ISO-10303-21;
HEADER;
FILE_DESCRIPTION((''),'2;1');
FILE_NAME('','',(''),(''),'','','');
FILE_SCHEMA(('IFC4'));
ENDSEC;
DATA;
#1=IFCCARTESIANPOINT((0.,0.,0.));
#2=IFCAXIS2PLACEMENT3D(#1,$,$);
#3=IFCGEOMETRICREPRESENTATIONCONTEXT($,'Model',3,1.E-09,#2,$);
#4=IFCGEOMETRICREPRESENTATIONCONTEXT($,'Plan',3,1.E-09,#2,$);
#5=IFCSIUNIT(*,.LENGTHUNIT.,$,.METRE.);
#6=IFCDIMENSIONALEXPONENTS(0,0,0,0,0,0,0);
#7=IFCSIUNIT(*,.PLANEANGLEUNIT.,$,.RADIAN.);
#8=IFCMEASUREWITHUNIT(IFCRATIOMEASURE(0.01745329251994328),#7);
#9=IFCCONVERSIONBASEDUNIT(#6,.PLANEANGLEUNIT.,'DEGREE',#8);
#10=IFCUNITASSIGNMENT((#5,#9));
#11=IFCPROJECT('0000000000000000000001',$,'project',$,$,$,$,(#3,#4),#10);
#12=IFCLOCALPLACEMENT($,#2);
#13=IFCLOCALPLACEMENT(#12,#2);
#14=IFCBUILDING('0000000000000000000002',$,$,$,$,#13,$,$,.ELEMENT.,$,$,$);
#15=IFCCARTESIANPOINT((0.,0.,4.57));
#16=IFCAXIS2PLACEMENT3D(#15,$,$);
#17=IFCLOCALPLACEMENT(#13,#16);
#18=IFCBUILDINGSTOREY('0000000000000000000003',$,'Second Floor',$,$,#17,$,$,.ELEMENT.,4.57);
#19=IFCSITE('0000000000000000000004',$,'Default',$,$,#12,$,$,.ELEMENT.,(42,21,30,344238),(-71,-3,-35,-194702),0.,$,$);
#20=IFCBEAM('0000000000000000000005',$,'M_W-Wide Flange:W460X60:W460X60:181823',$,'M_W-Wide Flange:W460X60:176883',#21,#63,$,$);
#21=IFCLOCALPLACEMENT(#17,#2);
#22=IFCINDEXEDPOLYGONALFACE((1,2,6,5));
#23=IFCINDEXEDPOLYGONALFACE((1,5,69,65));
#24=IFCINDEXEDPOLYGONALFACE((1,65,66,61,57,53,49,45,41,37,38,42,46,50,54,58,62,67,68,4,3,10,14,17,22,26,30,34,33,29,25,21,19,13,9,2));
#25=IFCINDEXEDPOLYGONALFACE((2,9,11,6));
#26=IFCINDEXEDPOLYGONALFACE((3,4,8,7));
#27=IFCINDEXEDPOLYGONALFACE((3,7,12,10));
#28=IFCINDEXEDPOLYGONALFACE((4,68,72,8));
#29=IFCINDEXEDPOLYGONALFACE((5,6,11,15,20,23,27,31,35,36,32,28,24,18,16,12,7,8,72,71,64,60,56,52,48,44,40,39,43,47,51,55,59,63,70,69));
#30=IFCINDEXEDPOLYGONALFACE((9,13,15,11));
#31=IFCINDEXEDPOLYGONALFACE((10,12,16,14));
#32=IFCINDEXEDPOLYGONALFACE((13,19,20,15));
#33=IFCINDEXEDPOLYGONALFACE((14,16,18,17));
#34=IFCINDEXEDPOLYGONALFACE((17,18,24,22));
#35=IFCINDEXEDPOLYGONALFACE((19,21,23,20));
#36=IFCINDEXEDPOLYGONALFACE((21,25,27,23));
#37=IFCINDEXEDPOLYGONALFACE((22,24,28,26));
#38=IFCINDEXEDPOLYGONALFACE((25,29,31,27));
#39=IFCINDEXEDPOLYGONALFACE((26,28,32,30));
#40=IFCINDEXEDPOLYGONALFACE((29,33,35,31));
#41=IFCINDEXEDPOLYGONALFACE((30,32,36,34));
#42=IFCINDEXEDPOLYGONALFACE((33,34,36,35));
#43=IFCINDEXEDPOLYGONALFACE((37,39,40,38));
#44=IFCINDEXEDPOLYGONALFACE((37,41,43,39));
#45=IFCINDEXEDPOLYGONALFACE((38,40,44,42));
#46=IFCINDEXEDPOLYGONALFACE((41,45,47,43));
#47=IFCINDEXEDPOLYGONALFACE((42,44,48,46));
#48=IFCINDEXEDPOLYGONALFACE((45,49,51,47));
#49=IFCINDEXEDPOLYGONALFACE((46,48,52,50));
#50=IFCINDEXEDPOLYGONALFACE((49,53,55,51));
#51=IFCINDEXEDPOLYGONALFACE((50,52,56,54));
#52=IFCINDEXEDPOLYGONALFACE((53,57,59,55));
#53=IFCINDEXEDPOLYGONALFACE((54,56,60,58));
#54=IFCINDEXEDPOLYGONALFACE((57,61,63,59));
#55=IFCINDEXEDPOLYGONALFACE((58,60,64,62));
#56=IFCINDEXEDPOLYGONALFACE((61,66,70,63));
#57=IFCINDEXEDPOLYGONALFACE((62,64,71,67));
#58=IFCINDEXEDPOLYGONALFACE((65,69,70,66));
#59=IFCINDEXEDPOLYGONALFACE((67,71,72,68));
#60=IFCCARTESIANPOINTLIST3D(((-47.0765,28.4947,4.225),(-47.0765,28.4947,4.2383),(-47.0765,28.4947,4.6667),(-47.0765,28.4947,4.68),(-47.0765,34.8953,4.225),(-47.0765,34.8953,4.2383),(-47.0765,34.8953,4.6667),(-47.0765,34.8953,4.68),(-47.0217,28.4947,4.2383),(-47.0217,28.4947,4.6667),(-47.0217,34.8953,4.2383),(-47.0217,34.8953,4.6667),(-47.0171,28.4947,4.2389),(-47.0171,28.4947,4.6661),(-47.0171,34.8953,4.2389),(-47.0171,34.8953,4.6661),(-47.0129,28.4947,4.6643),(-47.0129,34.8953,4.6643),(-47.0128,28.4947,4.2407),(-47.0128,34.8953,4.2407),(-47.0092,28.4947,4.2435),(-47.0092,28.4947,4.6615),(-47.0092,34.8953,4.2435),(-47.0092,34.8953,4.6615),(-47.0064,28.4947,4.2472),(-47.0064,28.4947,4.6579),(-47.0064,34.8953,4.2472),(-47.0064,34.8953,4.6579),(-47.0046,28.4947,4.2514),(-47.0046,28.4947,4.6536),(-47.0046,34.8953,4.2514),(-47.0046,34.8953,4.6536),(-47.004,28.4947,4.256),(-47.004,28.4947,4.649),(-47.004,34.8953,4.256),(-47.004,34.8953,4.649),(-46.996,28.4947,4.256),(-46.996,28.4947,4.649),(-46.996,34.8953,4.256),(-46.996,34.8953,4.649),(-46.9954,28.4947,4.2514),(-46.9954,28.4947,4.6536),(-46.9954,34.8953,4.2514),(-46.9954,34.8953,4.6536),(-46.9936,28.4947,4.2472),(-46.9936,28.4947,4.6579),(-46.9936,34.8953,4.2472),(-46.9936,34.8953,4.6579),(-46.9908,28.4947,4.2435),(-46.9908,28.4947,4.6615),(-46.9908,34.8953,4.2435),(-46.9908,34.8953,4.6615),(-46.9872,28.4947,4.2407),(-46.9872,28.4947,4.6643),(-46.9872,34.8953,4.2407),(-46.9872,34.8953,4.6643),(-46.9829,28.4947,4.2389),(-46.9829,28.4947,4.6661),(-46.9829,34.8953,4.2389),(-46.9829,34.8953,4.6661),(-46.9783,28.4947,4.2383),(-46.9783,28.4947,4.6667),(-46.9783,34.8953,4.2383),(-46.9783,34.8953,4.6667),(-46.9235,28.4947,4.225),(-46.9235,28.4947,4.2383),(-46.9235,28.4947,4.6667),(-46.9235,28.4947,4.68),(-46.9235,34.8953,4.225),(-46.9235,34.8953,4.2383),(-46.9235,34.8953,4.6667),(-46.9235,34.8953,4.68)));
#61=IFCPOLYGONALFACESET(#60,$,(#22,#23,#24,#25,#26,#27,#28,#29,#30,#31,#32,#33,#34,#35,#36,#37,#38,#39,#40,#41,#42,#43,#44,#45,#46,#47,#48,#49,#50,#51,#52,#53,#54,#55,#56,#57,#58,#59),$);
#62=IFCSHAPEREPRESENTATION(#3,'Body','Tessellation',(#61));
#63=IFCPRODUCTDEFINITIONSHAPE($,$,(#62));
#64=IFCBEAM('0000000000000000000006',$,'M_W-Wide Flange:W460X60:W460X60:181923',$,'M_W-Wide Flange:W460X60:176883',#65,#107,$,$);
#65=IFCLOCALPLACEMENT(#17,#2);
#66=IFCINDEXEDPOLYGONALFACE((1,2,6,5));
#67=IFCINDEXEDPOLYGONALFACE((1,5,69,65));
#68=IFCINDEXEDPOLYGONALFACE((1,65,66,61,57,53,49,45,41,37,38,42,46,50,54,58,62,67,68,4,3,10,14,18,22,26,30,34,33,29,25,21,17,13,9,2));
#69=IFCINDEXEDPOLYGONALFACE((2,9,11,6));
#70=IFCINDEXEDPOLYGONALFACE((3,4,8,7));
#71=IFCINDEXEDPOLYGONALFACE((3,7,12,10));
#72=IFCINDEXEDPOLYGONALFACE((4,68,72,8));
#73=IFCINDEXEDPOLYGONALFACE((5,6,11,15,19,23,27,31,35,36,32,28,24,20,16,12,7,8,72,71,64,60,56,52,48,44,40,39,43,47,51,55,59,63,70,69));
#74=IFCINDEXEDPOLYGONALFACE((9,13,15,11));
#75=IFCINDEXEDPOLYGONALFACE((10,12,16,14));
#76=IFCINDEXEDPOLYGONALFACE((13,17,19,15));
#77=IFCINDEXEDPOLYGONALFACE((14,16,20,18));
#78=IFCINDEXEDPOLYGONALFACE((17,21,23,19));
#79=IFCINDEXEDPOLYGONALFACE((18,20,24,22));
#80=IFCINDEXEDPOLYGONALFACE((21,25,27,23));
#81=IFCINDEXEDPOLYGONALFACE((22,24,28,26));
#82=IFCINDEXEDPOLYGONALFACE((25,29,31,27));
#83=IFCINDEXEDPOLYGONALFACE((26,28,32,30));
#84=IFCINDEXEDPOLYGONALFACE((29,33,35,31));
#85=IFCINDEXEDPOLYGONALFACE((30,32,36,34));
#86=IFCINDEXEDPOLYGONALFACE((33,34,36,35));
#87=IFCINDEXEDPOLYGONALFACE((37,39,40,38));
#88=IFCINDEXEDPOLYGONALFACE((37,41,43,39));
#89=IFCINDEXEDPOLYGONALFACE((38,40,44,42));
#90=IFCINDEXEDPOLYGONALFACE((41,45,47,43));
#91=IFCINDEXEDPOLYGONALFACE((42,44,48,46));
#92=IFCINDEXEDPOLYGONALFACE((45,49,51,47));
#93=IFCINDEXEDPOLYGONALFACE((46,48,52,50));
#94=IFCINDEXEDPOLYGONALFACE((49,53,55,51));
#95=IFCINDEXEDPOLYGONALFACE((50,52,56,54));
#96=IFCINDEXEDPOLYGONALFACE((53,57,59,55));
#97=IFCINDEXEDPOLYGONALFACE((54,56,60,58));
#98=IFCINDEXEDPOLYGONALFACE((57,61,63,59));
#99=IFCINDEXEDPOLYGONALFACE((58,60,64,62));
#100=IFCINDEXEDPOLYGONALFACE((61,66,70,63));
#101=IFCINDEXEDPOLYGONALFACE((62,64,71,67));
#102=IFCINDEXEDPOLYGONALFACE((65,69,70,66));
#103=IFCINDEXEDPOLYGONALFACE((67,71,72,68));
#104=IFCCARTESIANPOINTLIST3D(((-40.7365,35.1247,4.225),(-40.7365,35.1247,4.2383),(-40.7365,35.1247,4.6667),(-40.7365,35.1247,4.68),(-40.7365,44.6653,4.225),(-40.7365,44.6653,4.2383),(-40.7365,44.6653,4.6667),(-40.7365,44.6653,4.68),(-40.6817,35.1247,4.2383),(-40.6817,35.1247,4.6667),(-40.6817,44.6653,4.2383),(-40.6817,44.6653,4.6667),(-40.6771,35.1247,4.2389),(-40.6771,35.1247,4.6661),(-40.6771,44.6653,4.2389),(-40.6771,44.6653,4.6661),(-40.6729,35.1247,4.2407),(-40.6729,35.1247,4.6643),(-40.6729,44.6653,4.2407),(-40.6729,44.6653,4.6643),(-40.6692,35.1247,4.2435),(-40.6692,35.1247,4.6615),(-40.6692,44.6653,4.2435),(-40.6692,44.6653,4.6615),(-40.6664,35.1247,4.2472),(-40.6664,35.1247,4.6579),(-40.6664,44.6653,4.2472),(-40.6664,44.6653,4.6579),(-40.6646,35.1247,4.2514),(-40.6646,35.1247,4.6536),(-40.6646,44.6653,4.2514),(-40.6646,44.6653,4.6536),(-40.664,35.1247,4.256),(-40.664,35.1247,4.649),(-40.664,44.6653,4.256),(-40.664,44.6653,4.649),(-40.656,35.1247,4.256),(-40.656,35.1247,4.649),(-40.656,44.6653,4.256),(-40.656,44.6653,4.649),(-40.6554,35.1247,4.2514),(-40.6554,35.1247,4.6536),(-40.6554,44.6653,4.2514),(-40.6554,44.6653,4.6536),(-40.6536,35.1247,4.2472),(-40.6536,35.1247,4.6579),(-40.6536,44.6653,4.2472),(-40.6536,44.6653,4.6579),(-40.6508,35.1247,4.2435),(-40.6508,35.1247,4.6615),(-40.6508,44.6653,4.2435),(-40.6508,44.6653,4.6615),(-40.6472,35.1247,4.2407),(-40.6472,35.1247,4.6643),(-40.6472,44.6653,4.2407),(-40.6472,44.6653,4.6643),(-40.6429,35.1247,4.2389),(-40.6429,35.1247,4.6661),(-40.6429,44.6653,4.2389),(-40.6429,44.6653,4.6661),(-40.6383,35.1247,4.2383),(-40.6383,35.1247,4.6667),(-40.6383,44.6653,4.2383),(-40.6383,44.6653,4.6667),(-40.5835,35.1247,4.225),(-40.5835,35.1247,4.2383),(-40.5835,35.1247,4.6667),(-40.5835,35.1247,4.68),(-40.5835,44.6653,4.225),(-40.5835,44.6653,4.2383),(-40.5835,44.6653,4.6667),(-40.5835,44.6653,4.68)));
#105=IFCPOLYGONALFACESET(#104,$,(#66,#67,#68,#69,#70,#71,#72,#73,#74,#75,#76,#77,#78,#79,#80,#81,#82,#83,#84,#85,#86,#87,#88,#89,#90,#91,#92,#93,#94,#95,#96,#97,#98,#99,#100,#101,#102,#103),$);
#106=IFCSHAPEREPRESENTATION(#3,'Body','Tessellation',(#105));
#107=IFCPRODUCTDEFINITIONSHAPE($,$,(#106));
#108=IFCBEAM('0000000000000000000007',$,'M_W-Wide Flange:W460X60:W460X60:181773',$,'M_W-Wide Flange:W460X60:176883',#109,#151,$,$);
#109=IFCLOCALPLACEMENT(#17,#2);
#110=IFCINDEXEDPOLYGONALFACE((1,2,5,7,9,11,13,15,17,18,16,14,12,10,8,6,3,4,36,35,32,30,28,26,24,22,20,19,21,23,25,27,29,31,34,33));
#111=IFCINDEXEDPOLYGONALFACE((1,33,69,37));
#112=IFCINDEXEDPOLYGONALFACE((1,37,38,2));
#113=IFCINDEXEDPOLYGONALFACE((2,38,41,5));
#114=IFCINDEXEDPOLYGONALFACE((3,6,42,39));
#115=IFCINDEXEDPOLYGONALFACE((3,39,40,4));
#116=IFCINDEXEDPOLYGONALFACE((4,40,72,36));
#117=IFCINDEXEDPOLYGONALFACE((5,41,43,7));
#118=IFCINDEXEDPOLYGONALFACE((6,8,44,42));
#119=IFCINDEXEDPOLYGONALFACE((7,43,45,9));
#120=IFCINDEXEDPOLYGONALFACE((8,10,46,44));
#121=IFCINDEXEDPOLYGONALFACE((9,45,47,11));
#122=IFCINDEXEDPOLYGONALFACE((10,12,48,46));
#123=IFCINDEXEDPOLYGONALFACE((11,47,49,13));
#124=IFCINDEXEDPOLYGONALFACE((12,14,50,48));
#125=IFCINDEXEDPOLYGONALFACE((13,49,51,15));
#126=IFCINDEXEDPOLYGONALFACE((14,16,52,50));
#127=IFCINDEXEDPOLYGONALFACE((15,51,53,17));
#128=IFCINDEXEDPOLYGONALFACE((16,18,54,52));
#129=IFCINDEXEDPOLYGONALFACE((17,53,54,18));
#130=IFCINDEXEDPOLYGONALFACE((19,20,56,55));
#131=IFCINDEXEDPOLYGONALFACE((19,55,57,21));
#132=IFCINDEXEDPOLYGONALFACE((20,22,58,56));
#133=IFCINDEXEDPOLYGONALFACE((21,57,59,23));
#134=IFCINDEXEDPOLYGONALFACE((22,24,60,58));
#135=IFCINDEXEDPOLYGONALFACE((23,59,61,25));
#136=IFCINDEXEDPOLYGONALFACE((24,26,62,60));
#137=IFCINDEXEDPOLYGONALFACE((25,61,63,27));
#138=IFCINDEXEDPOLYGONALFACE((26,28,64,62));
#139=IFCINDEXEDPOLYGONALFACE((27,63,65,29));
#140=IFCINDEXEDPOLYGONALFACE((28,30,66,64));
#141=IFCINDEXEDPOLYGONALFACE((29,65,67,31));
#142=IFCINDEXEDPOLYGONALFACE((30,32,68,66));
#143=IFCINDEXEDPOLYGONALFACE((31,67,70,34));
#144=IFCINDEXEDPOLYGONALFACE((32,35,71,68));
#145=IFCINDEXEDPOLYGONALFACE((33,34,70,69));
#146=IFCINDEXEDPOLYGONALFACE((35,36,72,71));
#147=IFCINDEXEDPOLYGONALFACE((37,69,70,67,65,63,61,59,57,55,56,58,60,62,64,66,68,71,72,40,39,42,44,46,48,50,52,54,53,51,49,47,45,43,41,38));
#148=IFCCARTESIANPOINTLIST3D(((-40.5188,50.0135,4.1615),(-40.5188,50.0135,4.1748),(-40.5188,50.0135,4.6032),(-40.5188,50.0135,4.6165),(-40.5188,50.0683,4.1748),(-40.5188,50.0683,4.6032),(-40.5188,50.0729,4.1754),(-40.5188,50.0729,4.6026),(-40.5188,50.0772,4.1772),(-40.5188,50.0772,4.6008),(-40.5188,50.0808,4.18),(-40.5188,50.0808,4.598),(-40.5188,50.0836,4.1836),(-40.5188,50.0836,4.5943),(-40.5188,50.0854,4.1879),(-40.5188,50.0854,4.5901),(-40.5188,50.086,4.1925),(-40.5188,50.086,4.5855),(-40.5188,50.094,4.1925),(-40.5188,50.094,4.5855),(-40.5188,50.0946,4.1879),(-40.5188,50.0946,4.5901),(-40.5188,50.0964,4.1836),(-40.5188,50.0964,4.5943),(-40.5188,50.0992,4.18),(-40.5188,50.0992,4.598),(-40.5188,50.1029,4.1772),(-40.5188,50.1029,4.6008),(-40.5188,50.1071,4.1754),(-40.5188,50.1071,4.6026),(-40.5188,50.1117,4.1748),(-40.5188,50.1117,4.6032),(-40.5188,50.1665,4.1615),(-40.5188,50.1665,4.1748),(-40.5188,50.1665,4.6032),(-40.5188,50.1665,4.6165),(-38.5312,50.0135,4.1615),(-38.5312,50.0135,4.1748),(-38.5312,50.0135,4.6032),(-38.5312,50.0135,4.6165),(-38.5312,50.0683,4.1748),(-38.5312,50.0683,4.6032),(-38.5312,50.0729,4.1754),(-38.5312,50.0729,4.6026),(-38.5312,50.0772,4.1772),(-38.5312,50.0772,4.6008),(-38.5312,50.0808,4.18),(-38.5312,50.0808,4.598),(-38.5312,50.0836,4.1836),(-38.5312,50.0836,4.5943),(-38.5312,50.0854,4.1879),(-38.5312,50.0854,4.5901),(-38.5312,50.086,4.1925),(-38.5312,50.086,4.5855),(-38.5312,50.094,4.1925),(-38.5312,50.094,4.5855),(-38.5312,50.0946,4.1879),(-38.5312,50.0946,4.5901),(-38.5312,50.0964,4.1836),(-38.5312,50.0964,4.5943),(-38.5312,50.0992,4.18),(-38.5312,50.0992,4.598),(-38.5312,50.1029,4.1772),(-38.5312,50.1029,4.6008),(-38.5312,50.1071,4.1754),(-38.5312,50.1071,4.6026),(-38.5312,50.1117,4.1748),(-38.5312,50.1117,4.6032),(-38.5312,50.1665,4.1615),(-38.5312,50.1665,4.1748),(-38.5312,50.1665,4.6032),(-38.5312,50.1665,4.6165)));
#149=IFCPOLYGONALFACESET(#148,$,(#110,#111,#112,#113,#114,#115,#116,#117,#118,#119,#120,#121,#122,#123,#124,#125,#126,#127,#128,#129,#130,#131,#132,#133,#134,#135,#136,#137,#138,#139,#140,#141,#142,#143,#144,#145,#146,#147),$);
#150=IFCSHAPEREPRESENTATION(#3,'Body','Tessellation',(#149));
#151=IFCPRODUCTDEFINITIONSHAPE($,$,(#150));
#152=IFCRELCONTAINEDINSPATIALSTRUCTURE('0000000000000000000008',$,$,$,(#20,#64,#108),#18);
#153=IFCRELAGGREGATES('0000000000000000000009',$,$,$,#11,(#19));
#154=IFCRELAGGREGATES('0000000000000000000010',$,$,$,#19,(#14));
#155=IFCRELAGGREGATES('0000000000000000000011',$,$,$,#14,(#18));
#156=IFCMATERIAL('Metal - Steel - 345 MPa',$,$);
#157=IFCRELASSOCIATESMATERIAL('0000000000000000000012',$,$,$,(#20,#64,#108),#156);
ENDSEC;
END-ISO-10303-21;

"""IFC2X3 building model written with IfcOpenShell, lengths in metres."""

from ifc_helpers import new_model, entity, si_unit, converted_unit, frame, frame_2d, origin, place, context, project, spatial, polyline, circle_curve, parameter, trimmed, segment, composite_curve, outline, extrude, material, element, save


model = new_model("IFC2X3")

# Units and contexts
model_context = context("Model", 3, precision=1e-09, world=origin())
plan_context = context("Plan", 3, precision=1e-09, world=origin())
ifc_project = project(units=[si_unit("LENGTHUNIT", "METRE"), converted_unit("PLANEANGLEUNIT", "DEGREE", entity("IfcRatioMeasure", 0.01745329251994328), si_unit("PLANEANGLEUNIT", "RADIAN"), dimensions=[0, 0, 0, 0, 0, 0, 0])], contexts=[model_context, plan_context])

# Site, building, storey
site_placement = place(None, origin())
site = spatial("IfcSite", under=ifc_project, at=site_placement, Name="Default", CompositionType="ELEMENT", RefLatitude=(42, 21, 30, 344238), RefLongitude=(-71, -3, -35, -194702), RefElevation=0.0)
building_placement = place(site_placement, origin())
building = spatial("IfcBuilding", under=site, at=building_placement, CompositionType="ELEMENT")
storey_placement = place(building_placement, frame((0.0, 0.0, 4.57)))
storey = spatial("IfcBuildingStorey", under=building, at=storey_placement, Name="Second Floor", CompositionType="ELEMENT", Elevation=4.57)

# Shared definitions
ifc_material_1 = material(Name="Metal - Steel - 345 MPa")

# Beams
beam_1_placement = place(storey_placement, frame((-47.0, 35.0072, 4.68), z_axis=(0.0, 0.0, 1.0), x_axis=(-1.0, 0.0, 0.0)))
element("IfcBeam", 1, at=beam_1_placement, inside=storey, material=ifc_material_1, Name="M_W-Wide Flange:W460X60:W460X60:181823", ObjectType="M_W-Wide Flange:W460X60:176883", context=model_context, shape_type="SweptSolid", body=[
    extrude(outline(composite_curve([segment(polyline([(0.2142, -0.0765), (0.2275, -0.0765)]), True, "CONTINUOUS"), segment(polyline([(0.2275, -0.0765), (0.2275, 0.0765)]), True, "CONTINUOUS"), segment(polyline([(0.2275, 0.0765), (0.2142, 0.0765)]), True, "CONTINUOUS"), segment(polyline([(0.2142, 0.0765), (0.2142, 0.0217)]), True, "CONTINUOUS"), segment(trimmed(circle_curve(frame_2d((0.1965, 0.0217), x_axis=(1.0, 0.0)), 0.0177), [parameter(270.0)], [parameter(360.0)], True, "PARAMETER"), False, "CONTINUOUS"), segment(polyline([(0.1965, 0.004), (-0.1965, 0.004)]), True, "CONTINUOUS"), segment(trimmed(circle_curve(frame_2d((-0.1965, 0.0217), x_axis=(0.0, -1.0)), 0.0177), [parameter(270.0)], [parameter(360.0)], True, "PARAMETER"), False, "CONTINUOUS"), segment(polyline([(-0.2142, 0.0217), (-0.2142, 0.0765)]), True, "CONTINUOUS"), segment(polyline([(-0.2142, 0.0765), (-0.2275, 0.0765)]), True, "CONTINUOUS"), segment(polyline([(-0.2275, 0.0765), (-0.2275, -0.0765)]), True, "CONTINUOUS"), segment(polyline([(-0.2275, -0.0765), (-0.2142, -0.0765)]), True, "CONTINUOUS"), segment(polyline([(-0.2142, -0.0765), (-0.2142, -0.0217)]), True, "CONTINUOUS"), segment(trimmed(circle_curve(frame_2d((-0.1965, -0.0217), x_axis=(-1.0, 0.0)), 0.0177), [parameter(270.0)], [parameter(360.0)], True, "PARAMETER"), False, "CONTINUOUS"), segment(polyline([(-0.1965, -0.004), (0.1965, -0.004)]), True, "CONTINUOUS"), segment(trimmed(circle_curve(frame_2d((0.1965, -0.0217), x_axis=(0.0, 1.0)), 0.0177), [parameter(270.0)], [parameter(0.0)], True, "PARAMETER"), False, "CONTINUOUS"), segment(polyline([(0.2142, -0.0217), (0.2142, -0.0765)]), True, "CONTINUOUS")], self_intersect=False)), frame((0.0, 6.5125, -0.2275), z_axis=(0.0, -1.0, 0.0), x_axis=(0.0, 0.0, -1.0)), (0.0, 0.0, 1.0), 6.4006),
])
beam_2_placement = place(storey_placement, frame((-40.66, 35.0119, 4.68)))
element("IfcBeam", 2, at=beam_2_placement, inside=storey, material=ifc_material_1, Name="M_W-Wide Flange:W460X60:W460X60:181923", ObjectType="M_W-Wide Flange:W460X60:176883", context=model_context, shape_type="SweptSolid", body=[
    extrude(outline(composite_curve([segment(polyline([(-0.0765, -0.2142), (-0.0765, -0.2275)]), True, "CONTINUOUS"), segment(polyline([(-0.0765, -0.2275), (0.0765, -0.2275)]), True, "CONTINUOUS"), segment(polyline([(0.0765, -0.2275), (0.0765, -0.2142)]), True, "CONTINUOUS"), segment(polyline([(0.0765, -0.2142), (0.0217, -0.2142)]), True, "CONTINUOUS"), segment(trimmed(circle_curve(frame_2d((0.0217, -0.1965), x_axis=(0.0, -1.0)), 0.0177), [parameter(270.0)], [parameter(360.0)], True, "PARAMETER"), False, "CONTINUOUS"), segment(polyline([(0.004, -0.1965), (0.004, 0.1965)]), True, "CONTINUOUS"), segment(trimmed(circle_curve(frame_2d((0.0217, 0.1965), x_axis=(-1.0, 0.0)), 0.0177), [parameter(270.0)], [parameter(360.0)], True, "PARAMETER"), False, "CONTINUOUS"), segment(polyline([(0.0217, 0.2142), (0.0765, 0.2142)]), True, "CONTINUOUS"), segment(polyline([(0.0765, 0.2142), (0.0765, 0.2275)]), True, "CONTINUOUS"), segment(polyline([(0.0765, 0.2275), (-0.0765, 0.2275)]), True, "CONTINUOUS"), segment(polyline([(-0.0765, 0.2275), (-0.0765, 0.2142)]), True, "CONTINUOUS"), segment(polyline([(-0.0765, 0.2142), (-0.0217, 0.2142)]), True, "CONTINUOUS"), segment(trimmed(circle_curve(frame_2d((-0.0217, 0.1965), x_axis=(0.0, 1.0)), 0.0177), [parameter(270.0)], [parameter(360.0)], True, "PARAMETER"), False, "CONTINUOUS"), segment(polyline([(-0.004, 0.1965), (-0.004, -0.1965)]), True, "CONTINUOUS"), segment(trimmed(circle_curve(frame_2d((-0.0217, -0.1965), x_axis=(1.0, 0.0)), 0.0177), [parameter(270.0)], [parameter(0.0)], True, "PARAMETER"), False, "CONTINUOUS"), segment(polyline([(-0.0217, -0.2142), (-0.0765, -0.2142)]), True, "CONTINUOUS")], self_intersect=False)), frame((0.0, 0.1128, -0.2275), z_axis=(0.0, -1.0, 0.0), x_axis=(1.0, 0.0, 0.0)), (0.0, 0.0, -1.0), 9.5406),
])
beam_3_placement = place(storey_placement, frame((-38.3983, 50.09, 4.6165), z_axis=(0.0, 0.0, 1.0), x_axis=(0.0, 1.0, 0.0)))
element("IfcBeam", 3, at=beam_3_placement, inside=storey, material=ifc_material_1, Name="M_W-Wide Flange:W460X60:W460X60:181773", ObjectType="M_W-Wide Flange:W460X60:176883", context=model_context, shape_type="SweptSolid", body=[
    extrude(outline(composite_curve([segment(polyline([(0.2142, -0.0765), (0.2275, -0.0765)]), True, "CONTINUOUS"), segment(polyline([(0.2275, -0.0765), (0.2275, 0.0765)]), True, "CONTINUOUS"), segment(polyline([(0.2275, 0.0765), (0.2142, 0.0765)]), True, "CONTINUOUS"), segment(polyline([(0.2142, 0.0765), (0.2142, 0.0217)]), True, "CONTINUOUS"), segment(trimmed(circle_curve(frame_2d((0.1965, 0.0217), x_axis=(1.0, 0.0)), 0.0177), [parameter(270.0)], [parameter(360.0)], True, "PARAMETER"), False, "CONTINUOUS"), segment(polyline([(0.1965, 0.004), (-0.1965, 0.004)]), True, "CONTINUOUS"), segment(trimmed(circle_curve(frame_2d((-0.1965, 0.0217), x_axis=(0.0, -1.0)), 0.0177), [parameter(270.0)], [parameter(360.0)], True, "PARAMETER"), False, "CONTINUOUS"), segment(polyline([(-0.2142, 0.0217), (-0.2142, 0.0765)]), True, "CONTINUOUS"), segment(polyline([(-0.2142, 0.0765), (-0.2275, 0.0765)]), True, "CONTINUOUS"), segment(polyline([(-0.2275, 0.0765), (-0.2275, -0.0765)]), True, "CONTINUOUS"), segment(polyline([(-0.2275, -0.0765), (-0.2142, -0.0765)]), True, "CONTINUOUS"), segment(polyline([(-0.2142, -0.0765), (-0.2142, -0.0217)]), True, "CONTINUOUS"), segment(trimmed(circle_curve(frame_2d((-0.1965, -0.0217), x_axis=(-1.0, 0.0)), 0.0177), [parameter(270.0)], [parameter(360.0)], True, "PARAMETER"), False, "CONTINUOUS"), segment(polyline([(-0.1965, -0.004), (0.1965, -0.004)]), True, "CONTINUOUS"), segment(trimmed(circle_curve(frame_2d((0.1965, -0.0217), x_axis=(0.0, 1.0)), 0.0177), [parameter(270.0)], [parameter(0.0)], True, "PARAMETER"), False, "CONTINUOUS"), segment(polyline([(0.2142, -0.0217), (0.2142, -0.0765)]), True, "CONTINUOUS")], self_intersect=False)), frame((0.0, 2.1205, -0.2275), z_axis=(0.0, -1.0, 0.0), x_axis=(0.0, 0.0, -1.0)), (0.0, 0.0, 1.0), 1.9876),
])

save(model, "model.ifc")
